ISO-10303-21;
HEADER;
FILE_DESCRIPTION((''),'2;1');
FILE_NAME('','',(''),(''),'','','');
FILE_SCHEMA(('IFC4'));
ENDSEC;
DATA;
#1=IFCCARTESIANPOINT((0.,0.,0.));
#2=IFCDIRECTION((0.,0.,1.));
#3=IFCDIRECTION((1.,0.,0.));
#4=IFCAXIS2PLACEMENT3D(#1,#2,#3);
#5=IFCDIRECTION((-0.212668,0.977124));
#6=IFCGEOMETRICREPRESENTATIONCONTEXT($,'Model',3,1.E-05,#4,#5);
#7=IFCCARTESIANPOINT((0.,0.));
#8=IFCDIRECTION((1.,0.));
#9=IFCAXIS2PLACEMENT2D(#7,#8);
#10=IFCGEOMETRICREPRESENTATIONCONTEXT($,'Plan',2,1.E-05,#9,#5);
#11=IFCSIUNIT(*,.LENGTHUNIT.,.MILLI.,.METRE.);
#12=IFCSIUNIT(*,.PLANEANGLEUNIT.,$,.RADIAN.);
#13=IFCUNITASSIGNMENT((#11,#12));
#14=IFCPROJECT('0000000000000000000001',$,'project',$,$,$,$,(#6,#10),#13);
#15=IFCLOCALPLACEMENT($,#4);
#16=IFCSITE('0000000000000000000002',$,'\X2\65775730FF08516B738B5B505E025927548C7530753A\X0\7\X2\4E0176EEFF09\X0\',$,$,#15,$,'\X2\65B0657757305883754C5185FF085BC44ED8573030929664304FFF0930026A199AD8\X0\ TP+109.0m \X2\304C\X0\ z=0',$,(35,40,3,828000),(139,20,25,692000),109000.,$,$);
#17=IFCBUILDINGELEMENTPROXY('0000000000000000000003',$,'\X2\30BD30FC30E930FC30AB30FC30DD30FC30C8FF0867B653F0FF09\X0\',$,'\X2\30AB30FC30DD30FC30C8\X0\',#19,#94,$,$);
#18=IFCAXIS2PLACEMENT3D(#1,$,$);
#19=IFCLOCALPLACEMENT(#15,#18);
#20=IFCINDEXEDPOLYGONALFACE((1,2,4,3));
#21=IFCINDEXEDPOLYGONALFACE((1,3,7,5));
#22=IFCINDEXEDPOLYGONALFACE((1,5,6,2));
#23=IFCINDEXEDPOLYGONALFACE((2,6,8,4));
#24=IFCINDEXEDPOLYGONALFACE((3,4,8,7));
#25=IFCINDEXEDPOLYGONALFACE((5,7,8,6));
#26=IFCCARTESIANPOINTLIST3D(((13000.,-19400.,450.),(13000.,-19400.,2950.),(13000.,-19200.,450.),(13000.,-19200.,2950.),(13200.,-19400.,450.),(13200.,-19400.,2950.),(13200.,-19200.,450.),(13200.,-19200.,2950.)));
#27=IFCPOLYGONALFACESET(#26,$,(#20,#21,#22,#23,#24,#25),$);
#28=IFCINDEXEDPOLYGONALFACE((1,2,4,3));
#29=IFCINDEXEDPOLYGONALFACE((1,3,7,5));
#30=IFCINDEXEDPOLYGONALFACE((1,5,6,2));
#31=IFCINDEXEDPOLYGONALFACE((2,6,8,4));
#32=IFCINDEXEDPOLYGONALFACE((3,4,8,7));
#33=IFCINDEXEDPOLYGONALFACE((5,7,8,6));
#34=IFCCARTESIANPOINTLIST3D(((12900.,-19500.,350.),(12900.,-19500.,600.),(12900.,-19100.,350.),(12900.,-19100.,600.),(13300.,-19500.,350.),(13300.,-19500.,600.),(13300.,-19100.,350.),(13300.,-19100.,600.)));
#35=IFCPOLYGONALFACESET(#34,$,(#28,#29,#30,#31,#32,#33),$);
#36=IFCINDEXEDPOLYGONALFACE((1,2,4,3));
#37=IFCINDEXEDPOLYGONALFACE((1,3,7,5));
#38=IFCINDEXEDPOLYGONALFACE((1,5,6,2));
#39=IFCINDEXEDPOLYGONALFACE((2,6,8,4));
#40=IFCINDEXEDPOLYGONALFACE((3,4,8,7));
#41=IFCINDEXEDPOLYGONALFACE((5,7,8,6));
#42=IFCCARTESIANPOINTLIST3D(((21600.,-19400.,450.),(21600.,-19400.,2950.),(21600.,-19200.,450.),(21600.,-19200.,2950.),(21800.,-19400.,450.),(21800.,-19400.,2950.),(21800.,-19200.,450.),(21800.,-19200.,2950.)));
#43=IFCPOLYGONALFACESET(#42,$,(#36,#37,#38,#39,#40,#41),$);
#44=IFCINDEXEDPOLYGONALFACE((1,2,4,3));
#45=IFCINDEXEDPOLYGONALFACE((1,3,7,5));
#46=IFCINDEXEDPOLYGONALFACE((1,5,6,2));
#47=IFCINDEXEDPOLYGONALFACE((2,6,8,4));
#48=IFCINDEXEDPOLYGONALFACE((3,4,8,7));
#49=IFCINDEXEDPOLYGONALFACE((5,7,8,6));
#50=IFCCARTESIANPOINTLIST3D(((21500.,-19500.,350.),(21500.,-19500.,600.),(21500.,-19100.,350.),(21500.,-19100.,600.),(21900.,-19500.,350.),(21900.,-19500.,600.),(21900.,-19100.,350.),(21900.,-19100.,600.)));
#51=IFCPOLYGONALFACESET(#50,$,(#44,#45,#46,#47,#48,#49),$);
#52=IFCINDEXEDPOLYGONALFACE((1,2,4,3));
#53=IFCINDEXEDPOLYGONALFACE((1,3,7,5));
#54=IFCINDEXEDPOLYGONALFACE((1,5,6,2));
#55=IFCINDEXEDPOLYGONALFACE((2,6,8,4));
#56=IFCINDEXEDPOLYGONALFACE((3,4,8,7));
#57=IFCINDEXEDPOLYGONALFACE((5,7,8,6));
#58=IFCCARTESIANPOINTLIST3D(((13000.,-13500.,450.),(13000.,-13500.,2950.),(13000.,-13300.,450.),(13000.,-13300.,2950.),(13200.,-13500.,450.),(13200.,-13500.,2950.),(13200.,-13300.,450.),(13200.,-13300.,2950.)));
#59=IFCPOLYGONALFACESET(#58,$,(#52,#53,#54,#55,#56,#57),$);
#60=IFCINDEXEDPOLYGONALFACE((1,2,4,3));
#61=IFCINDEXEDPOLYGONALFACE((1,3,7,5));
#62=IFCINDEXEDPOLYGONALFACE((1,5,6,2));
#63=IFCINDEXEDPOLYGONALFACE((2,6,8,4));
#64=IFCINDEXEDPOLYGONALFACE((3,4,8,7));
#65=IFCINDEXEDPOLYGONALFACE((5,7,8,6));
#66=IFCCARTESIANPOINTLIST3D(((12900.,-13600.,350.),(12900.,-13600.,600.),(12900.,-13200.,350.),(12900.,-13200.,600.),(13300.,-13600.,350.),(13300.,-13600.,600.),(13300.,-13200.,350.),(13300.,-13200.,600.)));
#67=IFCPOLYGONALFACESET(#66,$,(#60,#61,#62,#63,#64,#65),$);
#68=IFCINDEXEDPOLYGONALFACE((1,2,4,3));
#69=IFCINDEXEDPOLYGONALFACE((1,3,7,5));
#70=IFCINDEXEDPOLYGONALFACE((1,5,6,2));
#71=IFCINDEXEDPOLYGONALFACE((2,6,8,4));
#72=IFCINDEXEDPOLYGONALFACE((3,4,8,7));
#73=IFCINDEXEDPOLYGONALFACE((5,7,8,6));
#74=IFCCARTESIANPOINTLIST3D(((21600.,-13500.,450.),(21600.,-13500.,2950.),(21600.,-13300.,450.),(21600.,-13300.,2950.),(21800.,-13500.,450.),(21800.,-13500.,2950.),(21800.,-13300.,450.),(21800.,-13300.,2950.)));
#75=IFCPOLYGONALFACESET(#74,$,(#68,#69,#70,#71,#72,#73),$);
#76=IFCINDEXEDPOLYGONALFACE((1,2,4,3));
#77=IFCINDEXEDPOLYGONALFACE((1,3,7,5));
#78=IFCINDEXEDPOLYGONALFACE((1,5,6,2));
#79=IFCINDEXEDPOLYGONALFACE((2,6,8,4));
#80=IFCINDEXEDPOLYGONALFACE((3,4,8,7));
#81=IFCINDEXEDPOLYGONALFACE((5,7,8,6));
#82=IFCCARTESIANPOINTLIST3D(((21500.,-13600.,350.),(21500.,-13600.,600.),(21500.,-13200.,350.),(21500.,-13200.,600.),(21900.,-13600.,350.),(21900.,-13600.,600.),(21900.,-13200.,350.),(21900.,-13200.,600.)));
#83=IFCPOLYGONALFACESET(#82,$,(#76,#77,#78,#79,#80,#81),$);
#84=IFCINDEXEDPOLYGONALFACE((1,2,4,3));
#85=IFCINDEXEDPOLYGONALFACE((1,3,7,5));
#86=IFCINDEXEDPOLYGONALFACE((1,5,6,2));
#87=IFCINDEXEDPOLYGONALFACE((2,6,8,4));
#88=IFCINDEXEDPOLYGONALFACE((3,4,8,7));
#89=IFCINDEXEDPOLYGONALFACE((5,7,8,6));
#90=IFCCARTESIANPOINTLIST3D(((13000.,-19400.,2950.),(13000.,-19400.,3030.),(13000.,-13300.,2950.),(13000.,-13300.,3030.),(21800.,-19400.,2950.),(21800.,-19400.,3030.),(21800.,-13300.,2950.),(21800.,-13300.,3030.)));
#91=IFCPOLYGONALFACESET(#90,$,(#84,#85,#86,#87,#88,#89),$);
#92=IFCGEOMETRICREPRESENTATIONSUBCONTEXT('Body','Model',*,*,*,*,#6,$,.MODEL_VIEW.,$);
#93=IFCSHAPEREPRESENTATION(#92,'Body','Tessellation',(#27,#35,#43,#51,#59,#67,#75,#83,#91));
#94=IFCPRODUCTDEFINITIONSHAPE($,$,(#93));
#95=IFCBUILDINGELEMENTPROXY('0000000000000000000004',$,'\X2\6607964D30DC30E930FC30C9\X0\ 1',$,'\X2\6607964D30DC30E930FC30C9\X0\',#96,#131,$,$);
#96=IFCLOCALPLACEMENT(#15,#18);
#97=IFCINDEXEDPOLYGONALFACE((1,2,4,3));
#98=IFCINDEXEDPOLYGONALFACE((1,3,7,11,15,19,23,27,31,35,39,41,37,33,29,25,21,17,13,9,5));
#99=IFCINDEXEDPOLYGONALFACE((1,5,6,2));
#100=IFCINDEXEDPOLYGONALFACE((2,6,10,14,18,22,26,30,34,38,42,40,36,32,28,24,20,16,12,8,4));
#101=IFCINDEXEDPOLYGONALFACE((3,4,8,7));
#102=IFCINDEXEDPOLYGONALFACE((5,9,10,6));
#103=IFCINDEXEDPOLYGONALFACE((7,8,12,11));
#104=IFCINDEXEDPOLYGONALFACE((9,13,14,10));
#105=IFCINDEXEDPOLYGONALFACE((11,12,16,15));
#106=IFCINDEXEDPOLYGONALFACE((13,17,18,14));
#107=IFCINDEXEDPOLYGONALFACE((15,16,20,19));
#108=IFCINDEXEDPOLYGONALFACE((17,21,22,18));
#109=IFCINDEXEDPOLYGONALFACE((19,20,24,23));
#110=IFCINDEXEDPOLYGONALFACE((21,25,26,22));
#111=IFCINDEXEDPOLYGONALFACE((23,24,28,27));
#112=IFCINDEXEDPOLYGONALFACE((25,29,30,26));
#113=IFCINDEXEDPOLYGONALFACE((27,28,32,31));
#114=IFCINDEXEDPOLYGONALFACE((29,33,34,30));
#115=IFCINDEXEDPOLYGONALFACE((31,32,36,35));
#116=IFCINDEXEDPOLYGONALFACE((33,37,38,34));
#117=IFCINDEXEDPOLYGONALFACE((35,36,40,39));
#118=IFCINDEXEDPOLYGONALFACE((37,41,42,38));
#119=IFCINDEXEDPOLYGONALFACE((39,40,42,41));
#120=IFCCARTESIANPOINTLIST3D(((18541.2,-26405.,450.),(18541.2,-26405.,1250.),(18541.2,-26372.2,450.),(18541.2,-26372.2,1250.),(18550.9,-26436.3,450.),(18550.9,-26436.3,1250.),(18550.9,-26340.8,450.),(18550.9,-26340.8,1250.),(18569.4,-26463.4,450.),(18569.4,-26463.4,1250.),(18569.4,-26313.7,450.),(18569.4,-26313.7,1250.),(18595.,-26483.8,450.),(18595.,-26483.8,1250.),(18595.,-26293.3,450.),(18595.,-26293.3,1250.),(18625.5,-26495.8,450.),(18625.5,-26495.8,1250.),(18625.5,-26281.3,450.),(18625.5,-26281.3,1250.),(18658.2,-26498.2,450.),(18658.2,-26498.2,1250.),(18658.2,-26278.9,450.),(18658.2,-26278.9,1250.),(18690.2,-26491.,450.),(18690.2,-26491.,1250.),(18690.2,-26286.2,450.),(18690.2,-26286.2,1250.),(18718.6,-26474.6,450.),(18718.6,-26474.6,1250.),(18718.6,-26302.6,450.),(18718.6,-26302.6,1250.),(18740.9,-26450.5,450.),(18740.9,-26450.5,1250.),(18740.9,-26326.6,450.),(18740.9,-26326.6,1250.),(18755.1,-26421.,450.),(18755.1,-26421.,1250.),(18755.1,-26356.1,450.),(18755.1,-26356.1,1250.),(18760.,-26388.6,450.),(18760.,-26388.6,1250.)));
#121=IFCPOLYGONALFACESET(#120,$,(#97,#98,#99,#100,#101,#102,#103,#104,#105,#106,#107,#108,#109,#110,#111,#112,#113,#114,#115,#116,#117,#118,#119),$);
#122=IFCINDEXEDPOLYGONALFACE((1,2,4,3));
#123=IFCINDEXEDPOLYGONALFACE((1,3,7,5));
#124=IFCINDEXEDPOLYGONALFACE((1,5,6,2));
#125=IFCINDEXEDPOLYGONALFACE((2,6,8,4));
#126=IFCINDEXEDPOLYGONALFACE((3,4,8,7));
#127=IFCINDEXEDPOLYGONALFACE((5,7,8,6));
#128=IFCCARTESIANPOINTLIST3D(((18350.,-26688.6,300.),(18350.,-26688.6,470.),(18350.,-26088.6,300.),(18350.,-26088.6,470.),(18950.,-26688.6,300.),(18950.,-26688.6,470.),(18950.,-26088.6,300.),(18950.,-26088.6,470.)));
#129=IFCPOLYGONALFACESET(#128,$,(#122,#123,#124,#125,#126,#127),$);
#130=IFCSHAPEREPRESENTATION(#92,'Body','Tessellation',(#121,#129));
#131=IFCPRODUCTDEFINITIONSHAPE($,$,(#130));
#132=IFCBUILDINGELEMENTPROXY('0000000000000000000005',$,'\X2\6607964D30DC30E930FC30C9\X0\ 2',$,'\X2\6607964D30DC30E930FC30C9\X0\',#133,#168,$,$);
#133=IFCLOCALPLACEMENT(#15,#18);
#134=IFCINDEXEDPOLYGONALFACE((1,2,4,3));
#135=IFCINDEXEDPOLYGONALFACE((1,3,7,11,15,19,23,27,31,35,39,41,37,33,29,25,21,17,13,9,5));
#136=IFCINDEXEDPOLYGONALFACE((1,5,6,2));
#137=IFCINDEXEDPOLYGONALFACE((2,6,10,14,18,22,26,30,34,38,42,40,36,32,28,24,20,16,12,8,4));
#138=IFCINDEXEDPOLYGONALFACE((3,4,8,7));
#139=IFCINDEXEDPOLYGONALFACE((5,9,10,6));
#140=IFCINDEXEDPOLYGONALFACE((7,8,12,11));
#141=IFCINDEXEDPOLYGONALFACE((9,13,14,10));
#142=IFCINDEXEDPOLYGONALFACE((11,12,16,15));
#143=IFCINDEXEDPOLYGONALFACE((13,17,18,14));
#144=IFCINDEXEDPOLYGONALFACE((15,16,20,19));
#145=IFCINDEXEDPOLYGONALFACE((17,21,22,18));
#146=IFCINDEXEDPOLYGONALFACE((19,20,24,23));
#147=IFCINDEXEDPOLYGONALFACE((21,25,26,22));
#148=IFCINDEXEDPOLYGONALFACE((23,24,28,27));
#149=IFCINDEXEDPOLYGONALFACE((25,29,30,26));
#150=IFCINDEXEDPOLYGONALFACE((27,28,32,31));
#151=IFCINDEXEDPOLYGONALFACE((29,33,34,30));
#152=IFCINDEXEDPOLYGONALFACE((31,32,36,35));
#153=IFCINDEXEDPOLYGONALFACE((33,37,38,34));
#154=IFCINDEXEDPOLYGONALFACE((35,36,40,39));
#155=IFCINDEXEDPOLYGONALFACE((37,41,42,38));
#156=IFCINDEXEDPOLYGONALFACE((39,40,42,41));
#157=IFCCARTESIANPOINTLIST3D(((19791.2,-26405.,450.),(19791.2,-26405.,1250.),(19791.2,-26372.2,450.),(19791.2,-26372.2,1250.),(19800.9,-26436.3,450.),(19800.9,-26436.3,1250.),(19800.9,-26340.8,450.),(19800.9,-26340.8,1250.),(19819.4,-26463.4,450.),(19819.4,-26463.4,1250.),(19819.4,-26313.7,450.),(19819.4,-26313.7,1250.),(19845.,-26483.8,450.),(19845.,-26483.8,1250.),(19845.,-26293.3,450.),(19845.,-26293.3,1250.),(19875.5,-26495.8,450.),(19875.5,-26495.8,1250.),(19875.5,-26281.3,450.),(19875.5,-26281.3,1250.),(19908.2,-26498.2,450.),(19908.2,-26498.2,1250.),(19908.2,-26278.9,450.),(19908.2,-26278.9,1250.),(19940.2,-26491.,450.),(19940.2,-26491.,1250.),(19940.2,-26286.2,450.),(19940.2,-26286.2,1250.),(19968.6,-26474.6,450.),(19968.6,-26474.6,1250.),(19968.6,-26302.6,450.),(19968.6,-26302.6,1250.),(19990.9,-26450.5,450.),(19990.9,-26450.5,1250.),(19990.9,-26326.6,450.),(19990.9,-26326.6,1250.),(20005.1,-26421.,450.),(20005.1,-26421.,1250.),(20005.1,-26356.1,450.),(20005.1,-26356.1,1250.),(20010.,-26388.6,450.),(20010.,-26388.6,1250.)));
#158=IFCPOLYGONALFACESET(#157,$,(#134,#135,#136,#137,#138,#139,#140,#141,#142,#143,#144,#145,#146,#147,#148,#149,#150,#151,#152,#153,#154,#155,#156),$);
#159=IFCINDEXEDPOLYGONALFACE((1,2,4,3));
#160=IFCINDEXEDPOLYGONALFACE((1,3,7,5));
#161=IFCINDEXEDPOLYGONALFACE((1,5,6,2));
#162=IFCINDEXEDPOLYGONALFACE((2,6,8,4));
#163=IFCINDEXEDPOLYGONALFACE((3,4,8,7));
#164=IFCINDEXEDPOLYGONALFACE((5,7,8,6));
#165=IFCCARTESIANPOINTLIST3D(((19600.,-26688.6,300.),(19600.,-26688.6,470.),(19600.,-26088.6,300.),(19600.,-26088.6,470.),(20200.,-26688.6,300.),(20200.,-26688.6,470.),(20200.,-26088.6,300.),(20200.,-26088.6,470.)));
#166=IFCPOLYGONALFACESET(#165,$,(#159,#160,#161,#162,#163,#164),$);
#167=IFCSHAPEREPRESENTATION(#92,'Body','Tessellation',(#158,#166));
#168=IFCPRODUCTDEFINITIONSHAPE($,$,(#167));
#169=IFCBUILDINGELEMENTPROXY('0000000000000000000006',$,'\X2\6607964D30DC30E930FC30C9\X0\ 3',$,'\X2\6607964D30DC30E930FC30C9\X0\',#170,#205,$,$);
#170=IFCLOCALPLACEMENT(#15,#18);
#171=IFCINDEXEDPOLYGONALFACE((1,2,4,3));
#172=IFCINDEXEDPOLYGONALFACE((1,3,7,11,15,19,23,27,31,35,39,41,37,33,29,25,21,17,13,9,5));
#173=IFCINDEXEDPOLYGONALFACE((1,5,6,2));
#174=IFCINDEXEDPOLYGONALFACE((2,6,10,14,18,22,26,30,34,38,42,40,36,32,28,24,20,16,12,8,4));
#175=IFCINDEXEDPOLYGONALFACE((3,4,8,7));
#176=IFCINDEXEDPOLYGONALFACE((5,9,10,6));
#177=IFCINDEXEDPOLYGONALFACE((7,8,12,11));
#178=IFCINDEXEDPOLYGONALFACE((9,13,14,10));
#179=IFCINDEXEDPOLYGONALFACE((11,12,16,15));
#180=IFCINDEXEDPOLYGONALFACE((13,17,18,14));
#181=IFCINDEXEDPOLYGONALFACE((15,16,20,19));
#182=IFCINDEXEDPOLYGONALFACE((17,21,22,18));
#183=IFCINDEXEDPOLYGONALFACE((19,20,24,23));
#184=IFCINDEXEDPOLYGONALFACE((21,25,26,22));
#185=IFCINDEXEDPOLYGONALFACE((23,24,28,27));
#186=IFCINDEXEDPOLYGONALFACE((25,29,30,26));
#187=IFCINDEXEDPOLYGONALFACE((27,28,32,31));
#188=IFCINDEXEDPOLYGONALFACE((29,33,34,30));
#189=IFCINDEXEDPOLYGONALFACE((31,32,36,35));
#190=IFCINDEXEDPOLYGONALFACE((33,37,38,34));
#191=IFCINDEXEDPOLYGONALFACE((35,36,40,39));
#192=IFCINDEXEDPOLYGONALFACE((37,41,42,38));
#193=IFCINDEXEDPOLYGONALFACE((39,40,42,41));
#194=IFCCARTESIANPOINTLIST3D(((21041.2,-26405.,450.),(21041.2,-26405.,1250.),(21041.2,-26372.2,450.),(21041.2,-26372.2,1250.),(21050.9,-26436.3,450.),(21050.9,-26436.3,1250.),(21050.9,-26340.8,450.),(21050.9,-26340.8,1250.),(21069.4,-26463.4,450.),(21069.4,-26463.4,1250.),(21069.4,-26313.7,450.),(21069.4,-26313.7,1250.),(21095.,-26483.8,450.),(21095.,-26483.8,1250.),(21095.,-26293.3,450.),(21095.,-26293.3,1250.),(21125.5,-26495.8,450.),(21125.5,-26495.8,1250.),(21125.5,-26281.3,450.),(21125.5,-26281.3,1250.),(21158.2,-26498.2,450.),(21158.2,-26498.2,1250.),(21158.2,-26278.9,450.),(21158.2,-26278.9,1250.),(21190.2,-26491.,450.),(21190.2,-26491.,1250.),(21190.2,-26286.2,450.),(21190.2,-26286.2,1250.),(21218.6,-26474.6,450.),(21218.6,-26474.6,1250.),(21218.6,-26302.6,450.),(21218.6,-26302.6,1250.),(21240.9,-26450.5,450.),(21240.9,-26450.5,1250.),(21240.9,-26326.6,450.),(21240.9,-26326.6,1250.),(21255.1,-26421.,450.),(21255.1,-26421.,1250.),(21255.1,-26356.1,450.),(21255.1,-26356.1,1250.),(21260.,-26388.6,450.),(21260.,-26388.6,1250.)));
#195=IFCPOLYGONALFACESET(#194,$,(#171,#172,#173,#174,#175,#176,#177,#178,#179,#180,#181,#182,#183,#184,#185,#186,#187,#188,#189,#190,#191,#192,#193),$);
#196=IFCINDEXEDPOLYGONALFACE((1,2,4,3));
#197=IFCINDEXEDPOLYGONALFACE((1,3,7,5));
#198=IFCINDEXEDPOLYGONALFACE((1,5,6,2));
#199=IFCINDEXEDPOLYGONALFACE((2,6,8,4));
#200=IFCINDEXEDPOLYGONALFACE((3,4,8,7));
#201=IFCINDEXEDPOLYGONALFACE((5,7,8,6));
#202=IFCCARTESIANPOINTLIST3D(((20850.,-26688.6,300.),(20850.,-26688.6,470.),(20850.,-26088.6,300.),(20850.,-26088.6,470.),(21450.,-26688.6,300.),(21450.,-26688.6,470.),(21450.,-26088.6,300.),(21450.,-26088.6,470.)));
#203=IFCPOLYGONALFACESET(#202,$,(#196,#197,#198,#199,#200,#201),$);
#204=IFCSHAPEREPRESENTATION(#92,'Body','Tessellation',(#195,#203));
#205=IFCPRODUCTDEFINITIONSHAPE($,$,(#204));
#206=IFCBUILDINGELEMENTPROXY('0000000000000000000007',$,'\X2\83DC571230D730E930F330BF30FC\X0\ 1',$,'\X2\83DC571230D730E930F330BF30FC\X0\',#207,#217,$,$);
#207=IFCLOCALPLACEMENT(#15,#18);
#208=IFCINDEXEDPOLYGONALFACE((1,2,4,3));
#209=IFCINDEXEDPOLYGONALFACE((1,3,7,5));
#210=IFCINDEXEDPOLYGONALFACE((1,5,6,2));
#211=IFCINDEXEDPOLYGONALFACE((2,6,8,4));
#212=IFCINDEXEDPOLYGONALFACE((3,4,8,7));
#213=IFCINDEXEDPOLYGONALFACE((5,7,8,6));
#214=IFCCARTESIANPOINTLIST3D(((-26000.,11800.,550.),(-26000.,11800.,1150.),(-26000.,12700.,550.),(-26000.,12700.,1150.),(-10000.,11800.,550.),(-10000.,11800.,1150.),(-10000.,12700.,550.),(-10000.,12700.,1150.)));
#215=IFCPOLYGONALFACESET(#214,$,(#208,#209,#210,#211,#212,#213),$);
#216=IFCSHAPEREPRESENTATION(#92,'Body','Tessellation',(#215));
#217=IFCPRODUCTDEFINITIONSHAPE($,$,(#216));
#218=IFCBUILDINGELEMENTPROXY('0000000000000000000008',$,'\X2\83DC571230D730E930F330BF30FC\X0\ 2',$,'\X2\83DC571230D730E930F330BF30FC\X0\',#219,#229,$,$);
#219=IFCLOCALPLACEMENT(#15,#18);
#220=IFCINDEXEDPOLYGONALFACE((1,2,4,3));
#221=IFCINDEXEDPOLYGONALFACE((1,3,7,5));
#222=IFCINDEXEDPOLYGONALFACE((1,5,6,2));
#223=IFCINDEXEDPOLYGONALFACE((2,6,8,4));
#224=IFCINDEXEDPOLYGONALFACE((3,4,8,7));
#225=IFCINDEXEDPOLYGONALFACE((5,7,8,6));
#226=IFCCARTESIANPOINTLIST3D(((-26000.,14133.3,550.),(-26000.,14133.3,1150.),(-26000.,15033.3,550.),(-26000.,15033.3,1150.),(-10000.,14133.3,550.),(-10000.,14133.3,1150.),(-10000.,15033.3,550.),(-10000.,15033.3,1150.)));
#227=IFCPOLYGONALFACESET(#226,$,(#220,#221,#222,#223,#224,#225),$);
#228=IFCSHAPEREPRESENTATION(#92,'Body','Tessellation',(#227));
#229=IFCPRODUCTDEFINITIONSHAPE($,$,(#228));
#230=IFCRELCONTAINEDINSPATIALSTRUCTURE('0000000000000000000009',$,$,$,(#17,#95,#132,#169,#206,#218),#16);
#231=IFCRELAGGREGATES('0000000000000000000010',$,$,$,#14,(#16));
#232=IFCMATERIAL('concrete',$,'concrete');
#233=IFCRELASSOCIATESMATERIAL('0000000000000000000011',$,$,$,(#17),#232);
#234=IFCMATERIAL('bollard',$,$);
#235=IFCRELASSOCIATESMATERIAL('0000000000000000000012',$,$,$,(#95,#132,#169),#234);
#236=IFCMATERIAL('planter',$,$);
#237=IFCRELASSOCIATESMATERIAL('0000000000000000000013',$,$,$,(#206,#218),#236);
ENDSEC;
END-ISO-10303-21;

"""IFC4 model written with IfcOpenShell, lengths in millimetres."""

from ifc_helpers import new_model, si_unit, direction, frame, frame_2d, origin_with_axes, origin_2d_with_axis, place, context, subcontext, project, spatial, rectangle, circle, extrude, material, element, save


model = new_model("IFC4")

# Units and contexts
model_context = context("Model", 3, precision=1e-05, world=origin_with_axes(), true_north=direction((-0.212668, 0.977124)))
plan_context = context("Plan", 2, precision=1e-05, world=origin_2d_with_axis(), true_north=direction((-0.212668, 0.977124)))
body_context = subcontext(model_context, "Body", "Model", "MODEL_VIEW")
ifc_project = project(units=[si_unit("LENGTHUNIT", "METRE", prefix="MILLI"), si_unit("PLANEANGLEUNIT", "RADIAN")], contexts=[model_context, plan_context])

# Site
site_placement = place(None, origin_with_axes())
site = spatial("IfcSite", under=ifc_project, at=site_placement, Name="敷地（八王子市大和田町7丁目）", LongName="新敷地境界内（寄付地を除く）。標高 TP+109.0m が z=0", RefLatitude=(35, 40, 3, 828000), RefLongitude=(139, 20, 25, 692000), RefElevation=109000.0)

# Building element proxies
ifc_material_1 = material(Name="concrete", Category="concrete")
proxy_1_placement = place(site_placement, origin_with_axes())
element("IfcBuildingElementProxy", 1, at=proxy_1_placement, inside=site, material=ifc_material_1, Name="ソーラーカーポート（架台）", ObjectType="カーポート", context=body_context, shape_type="SweptSolid", body=[
    extrude(rectangle(XDim=200.0, YDim=200.0, at=frame_2d((13100.0, -19300.0))), frame((0.0, 0.0, 450.0)), (0.0, 0.0, 1.0), 2500.0),
    extrude(rectangle(XDim=400.0, YDim=400.0, at=frame_2d((13100.0, -19300.0))), frame((0.0, 0.0, 350.0)), (0.0, 0.0, 1.0), 250.0),
    extrude(rectangle(XDim=200.0, YDim=200.0, at=frame_2d((21700.0, -19300.0))), frame((0.0, 0.0, 450.0)), (0.0, 0.0, 1.0), 2500.0),
    extrude(rectangle(XDim=400.0, YDim=400.0, at=frame_2d((21700.0, -19300.0))), frame((0.0, 0.0, 350.0)), (0.0, 0.0, 1.0), 250.0),
    extrude(rectangle(XDim=200.0, YDim=200.0, at=frame_2d((13100.0, -13400.0))), frame((0.0, 0.0, 450.0)), (0.0, 0.0, 1.0), 2500.0),
    extrude(rectangle(XDim=400.0, YDim=400.0, at=frame_2d((13100.0, -13400.0))), frame((0.0, 0.0, 350.0)), (0.0, 0.0, 1.0), 250.0),
    extrude(rectangle(XDim=200.0, YDim=200.0, at=frame_2d((21700.0, -13400.0))), frame((0.0, 0.0, 450.0)), (0.0, 0.0, 1.0), 2500.0),
    extrude(rectangle(XDim=400.0, YDim=400.0, at=frame_2d((21700.0, -13400.0))), frame((0.0, 0.0, 350.0)), (0.0, 0.0, 1.0), 250.0),
    extrude(rectangle(XDim=8800.0, YDim=6100.0, at=frame_2d((17400.0, -16350.0))), frame((0.0, 0.0, 2950.0)), (0.0, 0.0, 1.0), 80.0),
])
ifc_material_2 = material(Name="bollard")
proxy_2_placement = place(site_placement, origin_with_axes())
element("IfcBuildingElementProxy", 2, at=proxy_2_placement, inside=site, material=ifc_material_2, Name="昇降ボラード 1", ObjectType="昇降ボラード", context=body_context, shape_type="SweptSolid", body=[
    extrude(circle(Radius=110.0, at=frame_2d((18650.0, -26388.6))), frame((0.0, 0.0, 450.0)), (0.0, 0.0, 1.0), 800.0),
    extrude(rectangle(XDim=600.0, YDim=600.0, at=frame_2d((18650.0, -26388.6))), frame((0.0, 0.0, 300.0)), (0.0, 0.0, 1.0), 170.0),
])
proxy_3_placement = place(site_placement, origin_with_axes())
element("IfcBuildingElementProxy", 3, at=proxy_3_placement, inside=site, material=ifc_material_2, Name="昇降ボラード 2", ObjectType="昇降ボラード", context=body_context, shape_type="SweptSolid", body=[
    extrude(circle(Radius=110.0, at=frame_2d((19900.0, -26388.6))), frame((0.0, 0.0, 450.0)), (0.0, 0.0, 1.0), 800.0),
    extrude(rectangle(XDim=600.0, YDim=600.0, at=frame_2d((19900.0, -26388.6))), frame((0.0, 0.0, 300.0)), (0.0, 0.0, 1.0), 170.0),
])
proxy_4_placement = place(site_placement, origin_with_axes())
element("IfcBuildingElementProxy", 4, at=proxy_4_placement, inside=site, material=ifc_material_2, Name="昇降ボラード 3", ObjectType="昇降ボラード", context=body_context, shape_type="SweptSolid", body=[
    extrude(circle(Radius=110.0, at=frame_2d((21150.0, -26388.6))), frame((0.0, 0.0, 450.0)), (0.0, 0.0, 1.0), 800.0),
    extrude(rectangle(XDim=600.0, YDim=600.0, at=frame_2d((21150.0, -26388.6))), frame((0.0, 0.0, 300.0)), (0.0, 0.0, 1.0), 170.0),
])
ifc_material_3 = material(Name="planter")
proxy_5_placement = place(site_placement, origin_with_axes())
element("IfcBuildingElementProxy", 5, at=proxy_5_placement, inside=site, material=ifc_material_3, Name="菜園プランター 1", ObjectType="菜園プランター", context=body_context, shape_type="SweptSolid", body=[
    extrude(rectangle(XDim=16000.0, YDim=900.0, at=frame_2d((-18000.0, 12250.0))), frame((0.0, 0.0, 550.0)), (0.0, 0.0, 1.0), 600.0),
])
proxy_6_placement = place(site_placement, origin_with_axes())
element("IfcBuildingElementProxy", 6, at=proxy_6_placement, inside=site, material=ifc_material_3, Name="菜園プランター 2", ObjectType="菜園プランター", context=body_context, shape_type="SweptSolid", body=[
    extrude(rectangle(XDim=16000.0, YDim=900.0, at=frame_2d((-18000.0, 14583.3))), frame((0.0, 0.0, 550.0)), (0.0, 0.0, 1.0), 600.0),
])

save(model, "model.ifc")
